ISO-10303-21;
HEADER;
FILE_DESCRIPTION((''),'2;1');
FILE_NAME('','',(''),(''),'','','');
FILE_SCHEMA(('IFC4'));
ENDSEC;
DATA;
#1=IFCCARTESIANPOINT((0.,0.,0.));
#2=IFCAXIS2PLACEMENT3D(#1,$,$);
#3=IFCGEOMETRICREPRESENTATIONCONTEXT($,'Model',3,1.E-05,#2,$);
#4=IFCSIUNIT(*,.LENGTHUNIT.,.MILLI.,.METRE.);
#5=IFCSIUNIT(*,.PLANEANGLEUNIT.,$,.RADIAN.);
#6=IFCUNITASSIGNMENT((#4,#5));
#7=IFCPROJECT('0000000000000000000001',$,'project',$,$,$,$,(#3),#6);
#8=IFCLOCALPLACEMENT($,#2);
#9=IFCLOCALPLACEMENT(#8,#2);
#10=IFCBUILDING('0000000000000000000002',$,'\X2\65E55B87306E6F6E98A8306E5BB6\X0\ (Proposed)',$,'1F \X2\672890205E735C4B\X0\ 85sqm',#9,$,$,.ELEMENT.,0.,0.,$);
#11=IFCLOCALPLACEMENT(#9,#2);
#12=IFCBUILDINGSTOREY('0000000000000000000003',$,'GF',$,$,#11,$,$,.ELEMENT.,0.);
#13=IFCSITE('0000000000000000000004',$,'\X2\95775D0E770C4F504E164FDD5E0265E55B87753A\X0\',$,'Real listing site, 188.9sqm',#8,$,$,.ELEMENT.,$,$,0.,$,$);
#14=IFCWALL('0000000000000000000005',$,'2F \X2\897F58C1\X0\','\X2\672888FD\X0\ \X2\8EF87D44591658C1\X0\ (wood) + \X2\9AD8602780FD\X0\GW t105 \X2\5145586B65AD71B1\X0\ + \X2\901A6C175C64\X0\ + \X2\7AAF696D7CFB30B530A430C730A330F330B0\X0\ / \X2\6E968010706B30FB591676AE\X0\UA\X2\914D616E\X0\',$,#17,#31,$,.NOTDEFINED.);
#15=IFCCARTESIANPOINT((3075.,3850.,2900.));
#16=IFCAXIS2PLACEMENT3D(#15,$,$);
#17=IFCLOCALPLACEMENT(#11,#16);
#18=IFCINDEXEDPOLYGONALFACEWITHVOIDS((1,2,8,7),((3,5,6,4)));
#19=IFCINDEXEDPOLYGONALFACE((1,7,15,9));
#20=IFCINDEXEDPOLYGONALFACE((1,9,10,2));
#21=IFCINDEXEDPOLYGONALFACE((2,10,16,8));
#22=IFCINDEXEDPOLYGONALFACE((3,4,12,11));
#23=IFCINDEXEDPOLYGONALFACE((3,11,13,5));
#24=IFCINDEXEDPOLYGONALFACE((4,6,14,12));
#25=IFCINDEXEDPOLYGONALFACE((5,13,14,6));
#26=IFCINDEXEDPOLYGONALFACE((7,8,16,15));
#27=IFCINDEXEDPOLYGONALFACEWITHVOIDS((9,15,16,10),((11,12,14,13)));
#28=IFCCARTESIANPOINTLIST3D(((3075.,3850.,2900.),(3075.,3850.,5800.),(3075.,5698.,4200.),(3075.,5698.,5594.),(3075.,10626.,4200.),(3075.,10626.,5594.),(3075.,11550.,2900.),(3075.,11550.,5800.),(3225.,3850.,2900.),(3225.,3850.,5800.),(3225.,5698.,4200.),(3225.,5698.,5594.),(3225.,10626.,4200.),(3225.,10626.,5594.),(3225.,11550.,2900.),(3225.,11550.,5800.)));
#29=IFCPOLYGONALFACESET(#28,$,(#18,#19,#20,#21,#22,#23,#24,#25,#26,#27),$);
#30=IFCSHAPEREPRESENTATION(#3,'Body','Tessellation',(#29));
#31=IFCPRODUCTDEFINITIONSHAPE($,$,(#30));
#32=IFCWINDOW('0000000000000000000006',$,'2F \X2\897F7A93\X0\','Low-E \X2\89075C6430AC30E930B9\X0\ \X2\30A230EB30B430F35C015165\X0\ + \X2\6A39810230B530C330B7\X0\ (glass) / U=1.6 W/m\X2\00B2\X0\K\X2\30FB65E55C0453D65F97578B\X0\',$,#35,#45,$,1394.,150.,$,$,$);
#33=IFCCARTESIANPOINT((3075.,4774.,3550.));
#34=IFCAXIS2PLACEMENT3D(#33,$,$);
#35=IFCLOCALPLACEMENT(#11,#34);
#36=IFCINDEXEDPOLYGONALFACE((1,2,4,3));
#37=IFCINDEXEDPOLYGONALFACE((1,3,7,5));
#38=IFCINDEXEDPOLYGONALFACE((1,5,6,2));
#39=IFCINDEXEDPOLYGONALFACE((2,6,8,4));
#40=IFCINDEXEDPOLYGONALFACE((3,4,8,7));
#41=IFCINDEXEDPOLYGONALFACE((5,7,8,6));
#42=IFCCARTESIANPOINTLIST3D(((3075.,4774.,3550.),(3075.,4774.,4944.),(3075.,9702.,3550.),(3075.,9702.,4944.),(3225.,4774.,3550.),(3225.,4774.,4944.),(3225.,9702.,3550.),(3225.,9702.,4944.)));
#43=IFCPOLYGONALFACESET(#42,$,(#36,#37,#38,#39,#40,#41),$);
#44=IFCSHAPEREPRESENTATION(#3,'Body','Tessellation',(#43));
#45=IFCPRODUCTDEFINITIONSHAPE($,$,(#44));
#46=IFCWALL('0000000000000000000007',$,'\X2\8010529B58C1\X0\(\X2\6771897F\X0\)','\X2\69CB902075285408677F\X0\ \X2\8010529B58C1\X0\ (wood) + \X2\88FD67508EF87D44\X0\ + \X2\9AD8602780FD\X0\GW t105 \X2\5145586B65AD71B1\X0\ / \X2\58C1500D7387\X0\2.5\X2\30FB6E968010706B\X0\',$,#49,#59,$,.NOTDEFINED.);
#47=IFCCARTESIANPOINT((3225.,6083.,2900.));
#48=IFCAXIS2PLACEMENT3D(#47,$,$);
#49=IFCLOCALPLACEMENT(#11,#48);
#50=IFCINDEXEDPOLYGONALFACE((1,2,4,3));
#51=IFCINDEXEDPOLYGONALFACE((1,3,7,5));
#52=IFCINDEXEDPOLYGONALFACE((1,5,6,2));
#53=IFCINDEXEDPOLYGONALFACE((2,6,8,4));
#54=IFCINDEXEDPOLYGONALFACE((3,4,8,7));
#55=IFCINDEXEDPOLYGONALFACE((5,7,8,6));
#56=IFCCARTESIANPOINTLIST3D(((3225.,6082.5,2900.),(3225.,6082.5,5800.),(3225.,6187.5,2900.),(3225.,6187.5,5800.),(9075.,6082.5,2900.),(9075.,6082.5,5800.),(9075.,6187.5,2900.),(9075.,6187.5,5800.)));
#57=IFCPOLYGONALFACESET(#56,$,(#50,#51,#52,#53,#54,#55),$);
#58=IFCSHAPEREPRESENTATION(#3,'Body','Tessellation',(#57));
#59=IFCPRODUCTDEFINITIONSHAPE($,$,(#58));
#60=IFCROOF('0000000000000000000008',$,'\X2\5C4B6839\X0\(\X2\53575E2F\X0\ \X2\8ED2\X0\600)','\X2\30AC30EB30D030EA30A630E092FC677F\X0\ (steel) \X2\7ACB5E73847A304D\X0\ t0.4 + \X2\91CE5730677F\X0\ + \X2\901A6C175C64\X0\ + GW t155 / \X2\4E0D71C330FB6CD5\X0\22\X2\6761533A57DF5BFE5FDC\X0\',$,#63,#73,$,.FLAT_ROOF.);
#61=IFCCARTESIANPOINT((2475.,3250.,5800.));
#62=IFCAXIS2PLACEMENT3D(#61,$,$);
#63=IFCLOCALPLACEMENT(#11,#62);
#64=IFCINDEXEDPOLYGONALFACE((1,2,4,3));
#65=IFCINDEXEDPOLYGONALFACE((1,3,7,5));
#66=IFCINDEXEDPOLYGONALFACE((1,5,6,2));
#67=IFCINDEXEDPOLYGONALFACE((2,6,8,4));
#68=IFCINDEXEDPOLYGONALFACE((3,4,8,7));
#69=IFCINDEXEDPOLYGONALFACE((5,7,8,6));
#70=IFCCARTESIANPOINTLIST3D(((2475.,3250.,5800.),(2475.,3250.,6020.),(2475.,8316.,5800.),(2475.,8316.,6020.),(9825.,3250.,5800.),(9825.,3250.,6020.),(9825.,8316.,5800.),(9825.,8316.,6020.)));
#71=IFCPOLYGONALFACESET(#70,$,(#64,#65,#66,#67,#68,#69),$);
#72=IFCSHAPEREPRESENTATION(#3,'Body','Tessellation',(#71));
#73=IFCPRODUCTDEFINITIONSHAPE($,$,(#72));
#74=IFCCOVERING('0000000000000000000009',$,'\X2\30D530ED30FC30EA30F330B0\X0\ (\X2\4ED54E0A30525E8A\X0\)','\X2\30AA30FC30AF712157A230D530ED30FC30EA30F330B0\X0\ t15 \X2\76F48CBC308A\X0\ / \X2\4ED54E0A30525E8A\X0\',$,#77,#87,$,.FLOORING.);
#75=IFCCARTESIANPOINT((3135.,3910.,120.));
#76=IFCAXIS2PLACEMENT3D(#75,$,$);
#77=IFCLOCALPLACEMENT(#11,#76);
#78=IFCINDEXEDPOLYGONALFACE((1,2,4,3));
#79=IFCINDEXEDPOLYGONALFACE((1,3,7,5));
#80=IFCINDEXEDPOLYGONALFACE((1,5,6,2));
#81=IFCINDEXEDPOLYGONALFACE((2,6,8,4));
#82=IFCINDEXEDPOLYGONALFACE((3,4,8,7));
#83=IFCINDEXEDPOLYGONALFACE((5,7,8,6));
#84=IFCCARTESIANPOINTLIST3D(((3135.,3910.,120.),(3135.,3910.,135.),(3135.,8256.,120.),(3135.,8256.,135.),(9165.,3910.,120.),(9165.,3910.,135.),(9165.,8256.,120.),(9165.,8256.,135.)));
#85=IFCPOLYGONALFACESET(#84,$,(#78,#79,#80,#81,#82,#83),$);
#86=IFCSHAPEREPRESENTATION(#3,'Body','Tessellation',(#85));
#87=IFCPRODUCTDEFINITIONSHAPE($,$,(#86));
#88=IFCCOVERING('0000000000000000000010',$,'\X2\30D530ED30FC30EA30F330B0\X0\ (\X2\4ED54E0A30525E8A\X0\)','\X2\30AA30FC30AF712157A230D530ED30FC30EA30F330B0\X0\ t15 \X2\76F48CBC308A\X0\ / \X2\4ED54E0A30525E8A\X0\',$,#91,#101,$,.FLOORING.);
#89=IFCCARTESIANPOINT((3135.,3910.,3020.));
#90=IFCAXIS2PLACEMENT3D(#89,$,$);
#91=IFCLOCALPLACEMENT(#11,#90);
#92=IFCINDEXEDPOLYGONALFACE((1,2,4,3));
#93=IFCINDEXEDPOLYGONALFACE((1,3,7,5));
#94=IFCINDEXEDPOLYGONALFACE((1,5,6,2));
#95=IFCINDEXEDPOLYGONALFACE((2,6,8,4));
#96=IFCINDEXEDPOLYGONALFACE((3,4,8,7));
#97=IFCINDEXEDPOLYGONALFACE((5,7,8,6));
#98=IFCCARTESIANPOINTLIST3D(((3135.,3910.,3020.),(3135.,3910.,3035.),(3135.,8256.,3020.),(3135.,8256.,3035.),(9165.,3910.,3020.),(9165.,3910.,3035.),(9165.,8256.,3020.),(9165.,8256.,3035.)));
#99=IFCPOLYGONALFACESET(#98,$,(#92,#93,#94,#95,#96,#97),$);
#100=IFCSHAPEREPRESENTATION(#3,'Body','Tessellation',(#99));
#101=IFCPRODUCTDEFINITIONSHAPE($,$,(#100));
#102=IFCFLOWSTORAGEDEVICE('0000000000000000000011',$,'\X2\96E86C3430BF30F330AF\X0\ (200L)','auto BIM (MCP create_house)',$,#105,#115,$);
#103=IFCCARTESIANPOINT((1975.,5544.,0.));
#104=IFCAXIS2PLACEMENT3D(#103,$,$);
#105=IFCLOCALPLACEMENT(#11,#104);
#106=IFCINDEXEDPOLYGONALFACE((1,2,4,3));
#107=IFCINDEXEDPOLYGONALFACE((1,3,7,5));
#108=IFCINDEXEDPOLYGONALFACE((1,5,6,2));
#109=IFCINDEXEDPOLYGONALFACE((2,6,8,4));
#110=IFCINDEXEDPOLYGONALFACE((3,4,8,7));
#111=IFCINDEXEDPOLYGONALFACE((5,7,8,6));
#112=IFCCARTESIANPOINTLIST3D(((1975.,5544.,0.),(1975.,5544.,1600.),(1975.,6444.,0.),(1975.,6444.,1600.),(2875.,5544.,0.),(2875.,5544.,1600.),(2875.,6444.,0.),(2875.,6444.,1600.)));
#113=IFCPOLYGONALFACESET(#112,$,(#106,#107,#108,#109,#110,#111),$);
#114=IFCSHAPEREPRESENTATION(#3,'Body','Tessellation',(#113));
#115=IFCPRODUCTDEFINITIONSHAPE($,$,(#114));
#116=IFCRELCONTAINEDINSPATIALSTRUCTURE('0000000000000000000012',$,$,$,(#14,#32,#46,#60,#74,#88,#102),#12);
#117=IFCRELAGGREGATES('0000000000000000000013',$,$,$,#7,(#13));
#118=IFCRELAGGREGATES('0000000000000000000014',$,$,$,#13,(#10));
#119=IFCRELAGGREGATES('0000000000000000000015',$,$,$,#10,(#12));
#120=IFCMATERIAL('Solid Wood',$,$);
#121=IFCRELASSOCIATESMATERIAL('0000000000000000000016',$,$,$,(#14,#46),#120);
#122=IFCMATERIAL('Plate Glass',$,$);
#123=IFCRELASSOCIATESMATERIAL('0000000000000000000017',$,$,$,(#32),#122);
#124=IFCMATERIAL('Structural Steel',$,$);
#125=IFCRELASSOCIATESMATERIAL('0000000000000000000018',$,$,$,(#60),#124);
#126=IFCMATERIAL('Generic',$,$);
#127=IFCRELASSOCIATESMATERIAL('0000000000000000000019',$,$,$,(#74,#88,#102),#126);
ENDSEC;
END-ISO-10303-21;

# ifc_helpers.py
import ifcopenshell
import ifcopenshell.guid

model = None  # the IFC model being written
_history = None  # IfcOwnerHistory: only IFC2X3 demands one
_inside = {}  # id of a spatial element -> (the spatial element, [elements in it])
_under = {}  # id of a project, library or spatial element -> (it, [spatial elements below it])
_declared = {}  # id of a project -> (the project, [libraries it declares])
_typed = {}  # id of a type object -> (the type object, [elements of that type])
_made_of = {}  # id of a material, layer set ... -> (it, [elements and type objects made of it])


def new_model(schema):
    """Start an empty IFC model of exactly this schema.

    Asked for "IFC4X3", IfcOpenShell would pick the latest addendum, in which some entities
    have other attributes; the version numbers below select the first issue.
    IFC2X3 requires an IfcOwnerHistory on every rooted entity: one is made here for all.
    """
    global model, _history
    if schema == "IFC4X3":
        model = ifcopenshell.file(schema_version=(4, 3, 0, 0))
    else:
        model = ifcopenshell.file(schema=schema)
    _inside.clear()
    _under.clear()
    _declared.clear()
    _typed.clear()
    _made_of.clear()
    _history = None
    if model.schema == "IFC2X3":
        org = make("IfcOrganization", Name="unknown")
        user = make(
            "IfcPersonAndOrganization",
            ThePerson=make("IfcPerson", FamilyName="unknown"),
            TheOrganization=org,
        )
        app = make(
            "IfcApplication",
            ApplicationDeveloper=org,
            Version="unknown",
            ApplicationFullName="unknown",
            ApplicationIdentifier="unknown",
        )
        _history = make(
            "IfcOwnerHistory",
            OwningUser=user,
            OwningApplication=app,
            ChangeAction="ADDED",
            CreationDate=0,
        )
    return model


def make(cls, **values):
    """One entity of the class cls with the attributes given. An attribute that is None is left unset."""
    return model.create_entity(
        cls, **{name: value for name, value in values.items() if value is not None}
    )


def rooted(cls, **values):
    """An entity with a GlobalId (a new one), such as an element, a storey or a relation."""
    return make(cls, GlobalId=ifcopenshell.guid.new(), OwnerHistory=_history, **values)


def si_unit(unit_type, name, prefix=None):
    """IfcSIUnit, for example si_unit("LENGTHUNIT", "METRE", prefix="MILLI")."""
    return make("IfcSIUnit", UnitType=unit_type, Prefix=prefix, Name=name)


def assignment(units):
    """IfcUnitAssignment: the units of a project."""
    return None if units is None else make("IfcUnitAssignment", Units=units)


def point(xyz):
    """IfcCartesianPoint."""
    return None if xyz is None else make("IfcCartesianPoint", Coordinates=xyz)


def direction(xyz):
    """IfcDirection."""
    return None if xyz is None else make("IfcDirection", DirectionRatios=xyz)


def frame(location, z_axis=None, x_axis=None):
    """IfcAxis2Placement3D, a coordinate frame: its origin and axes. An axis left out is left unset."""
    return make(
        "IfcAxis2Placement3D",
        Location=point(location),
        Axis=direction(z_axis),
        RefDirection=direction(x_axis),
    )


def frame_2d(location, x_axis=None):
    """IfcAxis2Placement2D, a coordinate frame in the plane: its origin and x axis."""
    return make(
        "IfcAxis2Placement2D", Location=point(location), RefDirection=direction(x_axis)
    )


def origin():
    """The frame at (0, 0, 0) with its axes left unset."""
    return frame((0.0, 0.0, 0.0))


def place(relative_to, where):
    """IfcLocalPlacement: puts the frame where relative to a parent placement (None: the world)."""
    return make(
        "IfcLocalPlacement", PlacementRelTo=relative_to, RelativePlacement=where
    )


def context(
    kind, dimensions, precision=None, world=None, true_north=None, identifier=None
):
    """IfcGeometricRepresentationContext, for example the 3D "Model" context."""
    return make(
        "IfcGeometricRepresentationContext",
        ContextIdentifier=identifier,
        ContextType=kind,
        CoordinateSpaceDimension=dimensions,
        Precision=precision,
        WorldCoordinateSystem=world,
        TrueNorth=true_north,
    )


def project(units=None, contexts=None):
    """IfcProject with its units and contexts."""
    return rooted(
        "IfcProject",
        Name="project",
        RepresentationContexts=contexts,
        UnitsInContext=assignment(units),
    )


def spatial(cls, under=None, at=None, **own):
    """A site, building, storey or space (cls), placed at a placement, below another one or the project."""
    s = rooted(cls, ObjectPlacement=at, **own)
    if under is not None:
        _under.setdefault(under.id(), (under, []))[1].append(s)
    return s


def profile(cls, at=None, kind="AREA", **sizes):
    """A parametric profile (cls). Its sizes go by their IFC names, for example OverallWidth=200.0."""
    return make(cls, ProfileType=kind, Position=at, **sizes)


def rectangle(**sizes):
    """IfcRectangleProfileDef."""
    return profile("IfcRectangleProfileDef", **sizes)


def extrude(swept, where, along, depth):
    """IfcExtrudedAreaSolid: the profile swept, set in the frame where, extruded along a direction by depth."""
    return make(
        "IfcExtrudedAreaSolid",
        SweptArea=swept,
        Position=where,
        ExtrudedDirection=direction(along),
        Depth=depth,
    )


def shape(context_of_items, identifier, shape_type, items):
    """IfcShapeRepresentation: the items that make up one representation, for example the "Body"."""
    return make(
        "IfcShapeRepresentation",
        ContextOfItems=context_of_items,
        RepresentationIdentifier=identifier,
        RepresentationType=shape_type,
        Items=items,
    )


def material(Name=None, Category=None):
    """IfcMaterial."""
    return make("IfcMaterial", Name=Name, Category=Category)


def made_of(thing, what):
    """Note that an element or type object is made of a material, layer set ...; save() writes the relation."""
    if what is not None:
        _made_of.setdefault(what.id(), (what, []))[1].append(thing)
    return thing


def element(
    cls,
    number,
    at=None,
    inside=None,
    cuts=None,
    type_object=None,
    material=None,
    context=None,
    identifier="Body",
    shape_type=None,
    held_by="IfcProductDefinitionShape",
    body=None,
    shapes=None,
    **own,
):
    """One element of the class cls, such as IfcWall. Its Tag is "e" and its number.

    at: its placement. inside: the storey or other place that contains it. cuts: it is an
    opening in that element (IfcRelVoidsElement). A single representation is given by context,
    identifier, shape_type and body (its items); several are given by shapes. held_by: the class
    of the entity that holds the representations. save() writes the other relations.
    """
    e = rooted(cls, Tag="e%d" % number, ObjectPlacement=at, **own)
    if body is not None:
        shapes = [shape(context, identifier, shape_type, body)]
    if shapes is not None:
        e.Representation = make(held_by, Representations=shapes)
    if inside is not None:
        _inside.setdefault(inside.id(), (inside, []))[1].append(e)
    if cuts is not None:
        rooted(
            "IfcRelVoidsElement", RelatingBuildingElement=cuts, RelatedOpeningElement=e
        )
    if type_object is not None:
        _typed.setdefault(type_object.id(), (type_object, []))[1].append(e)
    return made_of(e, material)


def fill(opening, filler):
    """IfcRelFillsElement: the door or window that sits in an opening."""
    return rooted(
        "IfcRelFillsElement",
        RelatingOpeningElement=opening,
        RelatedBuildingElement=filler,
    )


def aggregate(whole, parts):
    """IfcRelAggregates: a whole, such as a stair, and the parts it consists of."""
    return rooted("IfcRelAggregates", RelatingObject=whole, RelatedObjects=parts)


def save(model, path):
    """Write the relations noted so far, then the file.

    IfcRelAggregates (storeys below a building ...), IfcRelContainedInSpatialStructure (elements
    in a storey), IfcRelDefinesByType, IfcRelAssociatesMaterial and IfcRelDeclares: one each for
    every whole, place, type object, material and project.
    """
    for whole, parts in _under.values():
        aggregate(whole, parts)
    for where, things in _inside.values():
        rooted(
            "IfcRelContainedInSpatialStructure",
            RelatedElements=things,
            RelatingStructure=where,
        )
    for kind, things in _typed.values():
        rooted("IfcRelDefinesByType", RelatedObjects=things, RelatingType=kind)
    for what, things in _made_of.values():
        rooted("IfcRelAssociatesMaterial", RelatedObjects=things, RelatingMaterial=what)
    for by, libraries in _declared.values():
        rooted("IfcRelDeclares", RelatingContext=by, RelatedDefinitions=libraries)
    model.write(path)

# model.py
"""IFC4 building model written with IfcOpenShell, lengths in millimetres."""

from ifc_helpers import new_model, si_unit, frame, frame_2d, origin, place, context, project, spatial, rectangle, extrude, material, element, fill, save


model = new_model("IFC4")

# Units and contexts
model_context = context("Model", 3, precision=1e-05, world=origin())
ifc_project = project(units=[si_unit("LENGTHUNIT", "METRE", prefix="MILLI"), si_unit("PLANEANGLEUNIT", "RADIAN")], contexts=[model_context])

# Site, building, storey
site_placement = place(None, origin())
site = spatial("IfcSite", under=ifc_project, at=site_placement, Name="長崎県佐世保市日宇町", ObjectType="Real listing site, 188.9sqm", CompositionType="ELEMENT", RefElevation=0.0)
building_placement = place(site_placement, origin())
building = spatial("IfcBuilding", under=site, at=building_placement, Name="日宇の潮風の家 (Proposed)", ObjectType="1F 木造平屋 85sqm", CompositionType="ELEMENT", ElevationOfRefHeight=0.0, ElevationOfTerrain=0.0)
storey_placement = place(building_placement, origin())
storey = spatial("IfcBuildingStorey", under=building, at=storey_placement, Name="GF", CompositionType="ELEMENT", Elevation=0.0)

# Shared definitions
ifc_material_1 = material(Name="Solid Wood")
ifc_material_2 = material(Name="Generic")

# Shared definitions
ifc_material_3 = material(Name="Plate Glass")

# Wall, opening, window
wall_1_placement = place(storey_placement, frame((3075.0, 3850.0, 2900.0)))
wall_1 = element("IfcWall", 1, at=wall_1_placement, inside=storey, material=ifc_material_1, Name="2F 西壁", Description="木製 軸組外壁 (wood) + 高性能GW t105 充填断熱 + 通気層 + 窯業系サイディング / 準耐火・外皮UA配慮", PredefinedType="NOTDEFINED", context=model_context, shape_type="SweptSolid", body=[
    extrude(rectangle(XDim=150.0, YDim=7700.0, at=frame_2d((75.0, 3850.0))), frame((3075.0, 3850.0, 2900.0)), (0.0, 0.0, 1.0), 2900.0),
])
opening_1_placement = place(storey_placement, frame((3075.0, 4774.0, 3550.0)))
opening_1 = element("IfcOpeningElement", 2, at=opening_1_placement, cuts=wall_1, PredefinedType="NOTDEFINED", context=model_context, shape_type="SweptSolid", body=[
    extrude(rectangle(XDim=150.0, YDim=4928.0, at=frame_2d((75.0, 2464.0))), frame((3075.0, 4774.0, 3550.0)), (0.0, 0.0, 1.0), 1394.0),
])
window_1_placement = place(storey_placement, frame((3075.0, 4774.0, 3550.0)))
window_1 = element("IfcWindow", 3, at=window_1_placement, inside=storey, material=ifc_material_3, Name="2F 西窓", Description="Low-E 複層ガラス アルゴン封入 + 樹脂サッシ (glass) / U=1.6 W/m²K・日射取得型", OverallHeight=1394.0, OverallWidth=150.0, context=model_context, shape_type="SweptSolid", body=[
    extrude(rectangle(XDim=150.0, YDim=4928.0, at=frame_2d((75.0, 2464.0))), frame((3075.0, 4774.0, 3550.0)), (0.0, 0.0, 1.0), 1394.0),
])
fill(opening_1, window_1)

# Wall
wall_2_placement = place(storey_placement, frame((3225.0, 6083.0, 2900.0)))
element("IfcWall", 4, at=wall_2_placement, inside=storey, material=ifc_material_1, Name="耐力壁(東西)", Description="構造用合板 耐力壁 (wood) + 製材軸組 + 高性能GW t105 充填断熱 / 壁倍率2.5・準耐火", PredefinedType="NOTDEFINED", context=model_context, shape_type="SweptSolid", body=[
    extrude(rectangle(XDim=5850.0, YDim=105.0, at=frame_2d((2925.0, 52.0))), frame((3225.0, 6083.0, 2900.0)), (0.0, 0.0, 1.0), 2900.0),
])

# Roof
ifc_material_4 = material(Name="Structural Steel")
for number, where, name in (
    (5, (2475.0, 3250.0, 5800.0), "屋根(南帯 軒600)"),
):
    element("IfcRoof", number, at=place(storey_placement, frame(where)), inside=storey, material=ifc_material_4, Name=name, Description="ガルバリウム鋼板 (steel) 立平葺き t0.4 + 野地板 + 通気層 + GW t155 / 不燃・法22条区域対応", PredefinedType="FLAT_ROOF", context=model_context, shape_type="SweptSolid", body=[
        extrude(rectangle(XDim=7350.0, YDim=5066.0, at=frame_2d((3675.0, 2533.0))), frame((2475.0, 3250.0, 5800.0)), (0.0, 0.0, 1.0), 220.0),
    ])

# Coverings
covering_1_placement = place(storey_placement, frame((3135.0, 3910.0, 120.0)))
element("IfcCovering", 6, at=covering_1_placement, inside=storey, material=ifc_material_2, Name="フローリング (仕上げ床)", Description="オーク無垢フローリング t15 直貼り / 仕上げ床", PredefinedType="FLOORING", context=model_context, shape_type="SweptSolid", body=[
    extrude(rectangle(XDim=6030.0, YDim=4346.0, at=frame_2d((3015.0, 2173.0))), frame((3135.0, 3910.0, 120.0)), (0.0, 0.0, 1.0), 15.0),
])
covering_2_placement = place(storey_placement, frame((3135.0, 3910.0, 3020.0)))
element("IfcCovering", 7, at=covering_2_placement, inside=storey, material=ifc_material_2, Name="フローリング (仕上げ床)", Description="オーク無垢フローリング t15 直貼り / 仕上げ床", PredefinedType="FLOORING", context=model_context, shape_type="SweptSolid", body=[
    extrude(rectangle(XDim=6030.0, YDim=4346.0, at=frame_2d((3015.0, 2173.0))), frame((3135.0, 3910.0, 3020.0)), (0.0, 0.0, 1.0), 15.0),
])

# Flow storage device
flow_storage_device_placement = place(storey_placement, frame((1975.0, 5544.0, 0.0)))
element("IfcFlowStorageDevice", 8, at=flow_storage_device_placement, inside=storey, material=ifc_material_2, Name="雨水タンク (200L)", Description="auto BIM (MCP create_house)", context=model_context, shape_type="SweptSolid", body=[
    extrude(rectangle(XDim=900.0, YDim=900.0, at=frame_2d((450.0, 450.0))), frame((1975.0, 5544.0, 0.0)), (0.0, 0.0, 1.0), 1600.0),
])

save(model, "model.ifc")
